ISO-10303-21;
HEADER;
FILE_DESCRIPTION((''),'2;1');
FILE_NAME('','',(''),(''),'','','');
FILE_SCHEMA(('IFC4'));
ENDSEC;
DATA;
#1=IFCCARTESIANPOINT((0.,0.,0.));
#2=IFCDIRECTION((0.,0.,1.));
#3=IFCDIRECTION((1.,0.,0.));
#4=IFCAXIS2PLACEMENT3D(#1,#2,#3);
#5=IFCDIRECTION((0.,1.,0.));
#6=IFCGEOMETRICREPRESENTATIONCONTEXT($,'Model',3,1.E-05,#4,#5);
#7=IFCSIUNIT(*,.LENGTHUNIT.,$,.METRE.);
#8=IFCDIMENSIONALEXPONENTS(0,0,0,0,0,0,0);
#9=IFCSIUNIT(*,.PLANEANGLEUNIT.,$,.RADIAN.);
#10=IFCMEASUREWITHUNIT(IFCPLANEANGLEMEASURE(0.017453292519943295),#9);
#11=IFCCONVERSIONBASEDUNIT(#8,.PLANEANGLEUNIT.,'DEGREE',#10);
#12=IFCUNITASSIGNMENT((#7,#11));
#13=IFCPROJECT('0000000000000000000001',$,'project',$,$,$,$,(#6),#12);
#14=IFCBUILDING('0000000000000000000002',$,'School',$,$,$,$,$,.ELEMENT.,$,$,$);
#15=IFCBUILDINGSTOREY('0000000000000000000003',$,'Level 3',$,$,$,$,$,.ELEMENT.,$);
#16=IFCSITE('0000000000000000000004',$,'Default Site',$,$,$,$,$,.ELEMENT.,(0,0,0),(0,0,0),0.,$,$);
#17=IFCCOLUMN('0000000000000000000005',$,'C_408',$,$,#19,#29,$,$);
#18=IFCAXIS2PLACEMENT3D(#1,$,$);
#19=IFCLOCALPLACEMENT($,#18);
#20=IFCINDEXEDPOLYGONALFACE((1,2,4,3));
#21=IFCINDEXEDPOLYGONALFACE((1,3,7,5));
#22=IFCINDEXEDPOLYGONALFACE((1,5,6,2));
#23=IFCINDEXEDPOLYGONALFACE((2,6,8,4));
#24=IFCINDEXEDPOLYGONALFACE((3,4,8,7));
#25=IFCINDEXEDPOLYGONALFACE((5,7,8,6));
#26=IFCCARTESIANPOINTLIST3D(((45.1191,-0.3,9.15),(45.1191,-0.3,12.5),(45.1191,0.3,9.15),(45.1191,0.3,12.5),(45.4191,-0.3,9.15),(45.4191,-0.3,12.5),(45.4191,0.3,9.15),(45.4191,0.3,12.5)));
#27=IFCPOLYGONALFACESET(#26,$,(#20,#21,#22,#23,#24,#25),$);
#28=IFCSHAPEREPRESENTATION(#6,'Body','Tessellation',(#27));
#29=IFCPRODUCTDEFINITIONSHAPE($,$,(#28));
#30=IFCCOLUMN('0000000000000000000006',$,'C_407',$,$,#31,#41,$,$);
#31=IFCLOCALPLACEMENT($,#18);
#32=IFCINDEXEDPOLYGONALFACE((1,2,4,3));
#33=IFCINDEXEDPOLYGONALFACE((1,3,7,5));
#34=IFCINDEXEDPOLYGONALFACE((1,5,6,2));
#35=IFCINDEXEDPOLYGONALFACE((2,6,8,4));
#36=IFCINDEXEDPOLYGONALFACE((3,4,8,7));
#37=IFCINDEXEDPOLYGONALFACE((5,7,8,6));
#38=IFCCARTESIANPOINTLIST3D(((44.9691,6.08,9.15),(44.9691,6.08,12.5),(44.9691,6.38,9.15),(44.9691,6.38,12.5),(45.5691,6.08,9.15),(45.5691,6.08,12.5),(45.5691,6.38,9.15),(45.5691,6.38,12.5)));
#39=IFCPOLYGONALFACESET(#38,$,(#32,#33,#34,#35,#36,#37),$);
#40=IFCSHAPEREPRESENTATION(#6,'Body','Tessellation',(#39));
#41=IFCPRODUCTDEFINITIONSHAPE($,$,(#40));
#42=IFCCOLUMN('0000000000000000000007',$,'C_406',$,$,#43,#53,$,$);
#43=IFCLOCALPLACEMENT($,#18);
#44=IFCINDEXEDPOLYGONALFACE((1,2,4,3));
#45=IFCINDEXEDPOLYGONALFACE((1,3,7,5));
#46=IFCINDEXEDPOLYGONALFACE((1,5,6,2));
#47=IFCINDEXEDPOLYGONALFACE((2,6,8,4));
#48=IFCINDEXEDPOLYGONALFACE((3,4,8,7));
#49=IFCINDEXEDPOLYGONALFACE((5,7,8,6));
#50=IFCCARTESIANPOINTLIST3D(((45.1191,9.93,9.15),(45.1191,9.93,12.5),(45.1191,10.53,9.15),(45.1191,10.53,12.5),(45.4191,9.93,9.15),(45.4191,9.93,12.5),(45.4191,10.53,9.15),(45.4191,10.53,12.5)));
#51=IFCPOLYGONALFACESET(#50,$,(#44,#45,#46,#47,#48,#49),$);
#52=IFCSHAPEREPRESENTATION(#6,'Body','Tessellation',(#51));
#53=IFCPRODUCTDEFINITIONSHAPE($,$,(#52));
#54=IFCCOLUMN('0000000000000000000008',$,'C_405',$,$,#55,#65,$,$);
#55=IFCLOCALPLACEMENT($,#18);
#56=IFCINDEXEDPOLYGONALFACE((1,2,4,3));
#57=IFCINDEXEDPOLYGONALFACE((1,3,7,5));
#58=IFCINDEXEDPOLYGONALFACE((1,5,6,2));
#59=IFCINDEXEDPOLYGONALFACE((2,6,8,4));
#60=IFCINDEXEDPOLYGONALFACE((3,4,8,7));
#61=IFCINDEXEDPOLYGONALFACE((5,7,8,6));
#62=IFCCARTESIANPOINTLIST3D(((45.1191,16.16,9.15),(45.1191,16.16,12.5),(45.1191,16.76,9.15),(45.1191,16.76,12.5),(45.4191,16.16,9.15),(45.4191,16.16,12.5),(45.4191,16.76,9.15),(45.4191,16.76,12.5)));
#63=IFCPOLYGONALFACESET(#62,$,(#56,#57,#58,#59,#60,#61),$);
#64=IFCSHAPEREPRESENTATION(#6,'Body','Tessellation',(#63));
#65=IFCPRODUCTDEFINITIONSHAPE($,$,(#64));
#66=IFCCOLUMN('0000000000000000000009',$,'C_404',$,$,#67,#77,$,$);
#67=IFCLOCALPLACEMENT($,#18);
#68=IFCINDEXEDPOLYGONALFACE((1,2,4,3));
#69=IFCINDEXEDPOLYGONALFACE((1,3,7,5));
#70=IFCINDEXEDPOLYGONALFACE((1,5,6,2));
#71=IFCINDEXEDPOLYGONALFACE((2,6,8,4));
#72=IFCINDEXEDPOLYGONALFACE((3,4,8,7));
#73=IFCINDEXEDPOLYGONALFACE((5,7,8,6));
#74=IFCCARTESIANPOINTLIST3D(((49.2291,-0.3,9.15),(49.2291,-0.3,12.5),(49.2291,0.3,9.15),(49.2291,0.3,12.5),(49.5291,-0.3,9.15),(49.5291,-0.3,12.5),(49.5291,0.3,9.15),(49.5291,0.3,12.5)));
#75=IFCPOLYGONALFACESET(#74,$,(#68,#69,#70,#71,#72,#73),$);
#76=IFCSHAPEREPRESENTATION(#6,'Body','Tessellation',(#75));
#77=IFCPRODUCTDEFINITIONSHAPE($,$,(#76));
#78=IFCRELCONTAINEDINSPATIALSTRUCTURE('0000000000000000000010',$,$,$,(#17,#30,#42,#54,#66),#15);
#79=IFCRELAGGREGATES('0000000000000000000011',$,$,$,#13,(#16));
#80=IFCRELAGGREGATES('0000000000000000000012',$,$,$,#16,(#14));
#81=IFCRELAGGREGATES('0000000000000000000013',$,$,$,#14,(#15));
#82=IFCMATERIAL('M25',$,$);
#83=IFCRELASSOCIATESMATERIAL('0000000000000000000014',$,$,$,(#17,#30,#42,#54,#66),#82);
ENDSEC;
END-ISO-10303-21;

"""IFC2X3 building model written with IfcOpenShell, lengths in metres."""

from ifc_helpers import new_model, entity, si_unit, converted_unit, direction, frame, frame_2d, origin_with_axes, place, context, project, spatial, rectangle, extrude, material, element, save


model = new_model("IFC2X3")

# Units and contexts
model_context = context("Model", 3, precision=1e-05, world=origin_with_axes(), true_north=direction((0.0, 1.0, 0.0)))
ifc_project = project(units=[si_unit("LENGTHUNIT", "METRE"), converted_unit("PLANEANGLEUNIT", "DEGREE", entity("IfcPlaneAngleMeasure", 0.017453292519943295), si_unit("PLANEANGLEUNIT", "RADIAN"), dimensions=[0, 0, 0, 0, 0, 0, 0])], contexts=[model_context])

# Site, building, storey
site = spatial("IfcSite", under=ifc_project, Name="Default Site", CompositionType="ELEMENT", RefLatitude=(0, 0, 0), RefLongitude=(0, 0, 0), RefElevation=0.0)
building = spatial("IfcBuilding", under=site, Name="School", CompositionType="ELEMENT")
storey = spatial("IfcBuildingStorey", under=building, Name="Level 3", CompositionType="ELEMENT")

# Columns
ifc_material = material(Name="M25")
placement = place(None, origin_with_axes())
element("IfcColumn", 1, at=placement, inside=storey, material=ifc_material, Name="C_408", context=model_context, shape_type="SweptSolid", body=[
    extrude(rectangle(XDim=0.3, YDim=0.6, at=frame_2d((0.0, 0.0), x_axis=(1.0, 0.0, 0.0))), frame((45.2691, 0.0, 9.15), z_axis=(0.0, 0.0, 1.0), x_axis=(1.0, 0.0, 0.0)), (0.0, 0.0, 1.0), 3.35),
])
element("IfcColumn", 2, at=placement, inside=storey, material=ifc_material, Name="C_407", context=model_context, shape_type="SweptSolid", body=[
    extrude(rectangle(XDim=0.6, YDim=0.3, at=frame_2d((0.0, 0.0), x_axis=(1.0, 0.0, 0.0))), frame((45.2691, 6.23, 9.15), z_axis=(0.0, 0.0, 1.0), x_axis=(1.0, 0.0, 0.0)), (0.0, 0.0, 1.0), 3.35),
])
element("IfcColumn", 3, at=placement, inside=storey, material=ifc_material, Name="C_406", context=model_context, shape_type="SweptSolid", body=[
    extrude(rectangle(XDim=0.3, YDim=0.6, at=frame_2d((0.0, 0.0), x_axis=(1.0, 0.0, 0.0))), frame((45.2691, 10.23, 9.15), z_axis=(0.0, 0.0, 1.0), x_axis=(1.0, 0.0, 0.0)), (0.0, 0.0, 1.0), 3.35),
])
element("IfcColumn", 4, at=placement, inside=storey, material=ifc_material, Name="C_405", context=model_context, shape_type="SweptSolid", body=[
    extrude(rectangle(XDim=0.3, YDim=0.6, at=frame_2d((0.0, 0.0), x_axis=(1.0, 0.0, 0.0))), frame((45.2691, 16.46, 9.15), z_axis=(0.0, 0.0, 1.0), x_axis=(1.0, 0.0, 0.0)), (0.0, 0.0, 1.0), 3.35),
])
element("IfcColumn", 5, at=placement, inside=storey, material=ifc_material, Name="C_404", context=model_context, shape_type="SweptSolid", body=[
    extrude(rectangle(XDim=0.3, YDim=0.6, at=frame_2d((0.0, 0.0), x_axis=(1.0, 0.0, 0.0))), frame((49.3791, 0.0, 9.15), z_axis=(0.0, 0.0, 1.0), x_axis=(1.0, 0.0, 0.0)), (0.0, 0.0, 1.0), 3.35),
])

save(model, "model.ifc")
